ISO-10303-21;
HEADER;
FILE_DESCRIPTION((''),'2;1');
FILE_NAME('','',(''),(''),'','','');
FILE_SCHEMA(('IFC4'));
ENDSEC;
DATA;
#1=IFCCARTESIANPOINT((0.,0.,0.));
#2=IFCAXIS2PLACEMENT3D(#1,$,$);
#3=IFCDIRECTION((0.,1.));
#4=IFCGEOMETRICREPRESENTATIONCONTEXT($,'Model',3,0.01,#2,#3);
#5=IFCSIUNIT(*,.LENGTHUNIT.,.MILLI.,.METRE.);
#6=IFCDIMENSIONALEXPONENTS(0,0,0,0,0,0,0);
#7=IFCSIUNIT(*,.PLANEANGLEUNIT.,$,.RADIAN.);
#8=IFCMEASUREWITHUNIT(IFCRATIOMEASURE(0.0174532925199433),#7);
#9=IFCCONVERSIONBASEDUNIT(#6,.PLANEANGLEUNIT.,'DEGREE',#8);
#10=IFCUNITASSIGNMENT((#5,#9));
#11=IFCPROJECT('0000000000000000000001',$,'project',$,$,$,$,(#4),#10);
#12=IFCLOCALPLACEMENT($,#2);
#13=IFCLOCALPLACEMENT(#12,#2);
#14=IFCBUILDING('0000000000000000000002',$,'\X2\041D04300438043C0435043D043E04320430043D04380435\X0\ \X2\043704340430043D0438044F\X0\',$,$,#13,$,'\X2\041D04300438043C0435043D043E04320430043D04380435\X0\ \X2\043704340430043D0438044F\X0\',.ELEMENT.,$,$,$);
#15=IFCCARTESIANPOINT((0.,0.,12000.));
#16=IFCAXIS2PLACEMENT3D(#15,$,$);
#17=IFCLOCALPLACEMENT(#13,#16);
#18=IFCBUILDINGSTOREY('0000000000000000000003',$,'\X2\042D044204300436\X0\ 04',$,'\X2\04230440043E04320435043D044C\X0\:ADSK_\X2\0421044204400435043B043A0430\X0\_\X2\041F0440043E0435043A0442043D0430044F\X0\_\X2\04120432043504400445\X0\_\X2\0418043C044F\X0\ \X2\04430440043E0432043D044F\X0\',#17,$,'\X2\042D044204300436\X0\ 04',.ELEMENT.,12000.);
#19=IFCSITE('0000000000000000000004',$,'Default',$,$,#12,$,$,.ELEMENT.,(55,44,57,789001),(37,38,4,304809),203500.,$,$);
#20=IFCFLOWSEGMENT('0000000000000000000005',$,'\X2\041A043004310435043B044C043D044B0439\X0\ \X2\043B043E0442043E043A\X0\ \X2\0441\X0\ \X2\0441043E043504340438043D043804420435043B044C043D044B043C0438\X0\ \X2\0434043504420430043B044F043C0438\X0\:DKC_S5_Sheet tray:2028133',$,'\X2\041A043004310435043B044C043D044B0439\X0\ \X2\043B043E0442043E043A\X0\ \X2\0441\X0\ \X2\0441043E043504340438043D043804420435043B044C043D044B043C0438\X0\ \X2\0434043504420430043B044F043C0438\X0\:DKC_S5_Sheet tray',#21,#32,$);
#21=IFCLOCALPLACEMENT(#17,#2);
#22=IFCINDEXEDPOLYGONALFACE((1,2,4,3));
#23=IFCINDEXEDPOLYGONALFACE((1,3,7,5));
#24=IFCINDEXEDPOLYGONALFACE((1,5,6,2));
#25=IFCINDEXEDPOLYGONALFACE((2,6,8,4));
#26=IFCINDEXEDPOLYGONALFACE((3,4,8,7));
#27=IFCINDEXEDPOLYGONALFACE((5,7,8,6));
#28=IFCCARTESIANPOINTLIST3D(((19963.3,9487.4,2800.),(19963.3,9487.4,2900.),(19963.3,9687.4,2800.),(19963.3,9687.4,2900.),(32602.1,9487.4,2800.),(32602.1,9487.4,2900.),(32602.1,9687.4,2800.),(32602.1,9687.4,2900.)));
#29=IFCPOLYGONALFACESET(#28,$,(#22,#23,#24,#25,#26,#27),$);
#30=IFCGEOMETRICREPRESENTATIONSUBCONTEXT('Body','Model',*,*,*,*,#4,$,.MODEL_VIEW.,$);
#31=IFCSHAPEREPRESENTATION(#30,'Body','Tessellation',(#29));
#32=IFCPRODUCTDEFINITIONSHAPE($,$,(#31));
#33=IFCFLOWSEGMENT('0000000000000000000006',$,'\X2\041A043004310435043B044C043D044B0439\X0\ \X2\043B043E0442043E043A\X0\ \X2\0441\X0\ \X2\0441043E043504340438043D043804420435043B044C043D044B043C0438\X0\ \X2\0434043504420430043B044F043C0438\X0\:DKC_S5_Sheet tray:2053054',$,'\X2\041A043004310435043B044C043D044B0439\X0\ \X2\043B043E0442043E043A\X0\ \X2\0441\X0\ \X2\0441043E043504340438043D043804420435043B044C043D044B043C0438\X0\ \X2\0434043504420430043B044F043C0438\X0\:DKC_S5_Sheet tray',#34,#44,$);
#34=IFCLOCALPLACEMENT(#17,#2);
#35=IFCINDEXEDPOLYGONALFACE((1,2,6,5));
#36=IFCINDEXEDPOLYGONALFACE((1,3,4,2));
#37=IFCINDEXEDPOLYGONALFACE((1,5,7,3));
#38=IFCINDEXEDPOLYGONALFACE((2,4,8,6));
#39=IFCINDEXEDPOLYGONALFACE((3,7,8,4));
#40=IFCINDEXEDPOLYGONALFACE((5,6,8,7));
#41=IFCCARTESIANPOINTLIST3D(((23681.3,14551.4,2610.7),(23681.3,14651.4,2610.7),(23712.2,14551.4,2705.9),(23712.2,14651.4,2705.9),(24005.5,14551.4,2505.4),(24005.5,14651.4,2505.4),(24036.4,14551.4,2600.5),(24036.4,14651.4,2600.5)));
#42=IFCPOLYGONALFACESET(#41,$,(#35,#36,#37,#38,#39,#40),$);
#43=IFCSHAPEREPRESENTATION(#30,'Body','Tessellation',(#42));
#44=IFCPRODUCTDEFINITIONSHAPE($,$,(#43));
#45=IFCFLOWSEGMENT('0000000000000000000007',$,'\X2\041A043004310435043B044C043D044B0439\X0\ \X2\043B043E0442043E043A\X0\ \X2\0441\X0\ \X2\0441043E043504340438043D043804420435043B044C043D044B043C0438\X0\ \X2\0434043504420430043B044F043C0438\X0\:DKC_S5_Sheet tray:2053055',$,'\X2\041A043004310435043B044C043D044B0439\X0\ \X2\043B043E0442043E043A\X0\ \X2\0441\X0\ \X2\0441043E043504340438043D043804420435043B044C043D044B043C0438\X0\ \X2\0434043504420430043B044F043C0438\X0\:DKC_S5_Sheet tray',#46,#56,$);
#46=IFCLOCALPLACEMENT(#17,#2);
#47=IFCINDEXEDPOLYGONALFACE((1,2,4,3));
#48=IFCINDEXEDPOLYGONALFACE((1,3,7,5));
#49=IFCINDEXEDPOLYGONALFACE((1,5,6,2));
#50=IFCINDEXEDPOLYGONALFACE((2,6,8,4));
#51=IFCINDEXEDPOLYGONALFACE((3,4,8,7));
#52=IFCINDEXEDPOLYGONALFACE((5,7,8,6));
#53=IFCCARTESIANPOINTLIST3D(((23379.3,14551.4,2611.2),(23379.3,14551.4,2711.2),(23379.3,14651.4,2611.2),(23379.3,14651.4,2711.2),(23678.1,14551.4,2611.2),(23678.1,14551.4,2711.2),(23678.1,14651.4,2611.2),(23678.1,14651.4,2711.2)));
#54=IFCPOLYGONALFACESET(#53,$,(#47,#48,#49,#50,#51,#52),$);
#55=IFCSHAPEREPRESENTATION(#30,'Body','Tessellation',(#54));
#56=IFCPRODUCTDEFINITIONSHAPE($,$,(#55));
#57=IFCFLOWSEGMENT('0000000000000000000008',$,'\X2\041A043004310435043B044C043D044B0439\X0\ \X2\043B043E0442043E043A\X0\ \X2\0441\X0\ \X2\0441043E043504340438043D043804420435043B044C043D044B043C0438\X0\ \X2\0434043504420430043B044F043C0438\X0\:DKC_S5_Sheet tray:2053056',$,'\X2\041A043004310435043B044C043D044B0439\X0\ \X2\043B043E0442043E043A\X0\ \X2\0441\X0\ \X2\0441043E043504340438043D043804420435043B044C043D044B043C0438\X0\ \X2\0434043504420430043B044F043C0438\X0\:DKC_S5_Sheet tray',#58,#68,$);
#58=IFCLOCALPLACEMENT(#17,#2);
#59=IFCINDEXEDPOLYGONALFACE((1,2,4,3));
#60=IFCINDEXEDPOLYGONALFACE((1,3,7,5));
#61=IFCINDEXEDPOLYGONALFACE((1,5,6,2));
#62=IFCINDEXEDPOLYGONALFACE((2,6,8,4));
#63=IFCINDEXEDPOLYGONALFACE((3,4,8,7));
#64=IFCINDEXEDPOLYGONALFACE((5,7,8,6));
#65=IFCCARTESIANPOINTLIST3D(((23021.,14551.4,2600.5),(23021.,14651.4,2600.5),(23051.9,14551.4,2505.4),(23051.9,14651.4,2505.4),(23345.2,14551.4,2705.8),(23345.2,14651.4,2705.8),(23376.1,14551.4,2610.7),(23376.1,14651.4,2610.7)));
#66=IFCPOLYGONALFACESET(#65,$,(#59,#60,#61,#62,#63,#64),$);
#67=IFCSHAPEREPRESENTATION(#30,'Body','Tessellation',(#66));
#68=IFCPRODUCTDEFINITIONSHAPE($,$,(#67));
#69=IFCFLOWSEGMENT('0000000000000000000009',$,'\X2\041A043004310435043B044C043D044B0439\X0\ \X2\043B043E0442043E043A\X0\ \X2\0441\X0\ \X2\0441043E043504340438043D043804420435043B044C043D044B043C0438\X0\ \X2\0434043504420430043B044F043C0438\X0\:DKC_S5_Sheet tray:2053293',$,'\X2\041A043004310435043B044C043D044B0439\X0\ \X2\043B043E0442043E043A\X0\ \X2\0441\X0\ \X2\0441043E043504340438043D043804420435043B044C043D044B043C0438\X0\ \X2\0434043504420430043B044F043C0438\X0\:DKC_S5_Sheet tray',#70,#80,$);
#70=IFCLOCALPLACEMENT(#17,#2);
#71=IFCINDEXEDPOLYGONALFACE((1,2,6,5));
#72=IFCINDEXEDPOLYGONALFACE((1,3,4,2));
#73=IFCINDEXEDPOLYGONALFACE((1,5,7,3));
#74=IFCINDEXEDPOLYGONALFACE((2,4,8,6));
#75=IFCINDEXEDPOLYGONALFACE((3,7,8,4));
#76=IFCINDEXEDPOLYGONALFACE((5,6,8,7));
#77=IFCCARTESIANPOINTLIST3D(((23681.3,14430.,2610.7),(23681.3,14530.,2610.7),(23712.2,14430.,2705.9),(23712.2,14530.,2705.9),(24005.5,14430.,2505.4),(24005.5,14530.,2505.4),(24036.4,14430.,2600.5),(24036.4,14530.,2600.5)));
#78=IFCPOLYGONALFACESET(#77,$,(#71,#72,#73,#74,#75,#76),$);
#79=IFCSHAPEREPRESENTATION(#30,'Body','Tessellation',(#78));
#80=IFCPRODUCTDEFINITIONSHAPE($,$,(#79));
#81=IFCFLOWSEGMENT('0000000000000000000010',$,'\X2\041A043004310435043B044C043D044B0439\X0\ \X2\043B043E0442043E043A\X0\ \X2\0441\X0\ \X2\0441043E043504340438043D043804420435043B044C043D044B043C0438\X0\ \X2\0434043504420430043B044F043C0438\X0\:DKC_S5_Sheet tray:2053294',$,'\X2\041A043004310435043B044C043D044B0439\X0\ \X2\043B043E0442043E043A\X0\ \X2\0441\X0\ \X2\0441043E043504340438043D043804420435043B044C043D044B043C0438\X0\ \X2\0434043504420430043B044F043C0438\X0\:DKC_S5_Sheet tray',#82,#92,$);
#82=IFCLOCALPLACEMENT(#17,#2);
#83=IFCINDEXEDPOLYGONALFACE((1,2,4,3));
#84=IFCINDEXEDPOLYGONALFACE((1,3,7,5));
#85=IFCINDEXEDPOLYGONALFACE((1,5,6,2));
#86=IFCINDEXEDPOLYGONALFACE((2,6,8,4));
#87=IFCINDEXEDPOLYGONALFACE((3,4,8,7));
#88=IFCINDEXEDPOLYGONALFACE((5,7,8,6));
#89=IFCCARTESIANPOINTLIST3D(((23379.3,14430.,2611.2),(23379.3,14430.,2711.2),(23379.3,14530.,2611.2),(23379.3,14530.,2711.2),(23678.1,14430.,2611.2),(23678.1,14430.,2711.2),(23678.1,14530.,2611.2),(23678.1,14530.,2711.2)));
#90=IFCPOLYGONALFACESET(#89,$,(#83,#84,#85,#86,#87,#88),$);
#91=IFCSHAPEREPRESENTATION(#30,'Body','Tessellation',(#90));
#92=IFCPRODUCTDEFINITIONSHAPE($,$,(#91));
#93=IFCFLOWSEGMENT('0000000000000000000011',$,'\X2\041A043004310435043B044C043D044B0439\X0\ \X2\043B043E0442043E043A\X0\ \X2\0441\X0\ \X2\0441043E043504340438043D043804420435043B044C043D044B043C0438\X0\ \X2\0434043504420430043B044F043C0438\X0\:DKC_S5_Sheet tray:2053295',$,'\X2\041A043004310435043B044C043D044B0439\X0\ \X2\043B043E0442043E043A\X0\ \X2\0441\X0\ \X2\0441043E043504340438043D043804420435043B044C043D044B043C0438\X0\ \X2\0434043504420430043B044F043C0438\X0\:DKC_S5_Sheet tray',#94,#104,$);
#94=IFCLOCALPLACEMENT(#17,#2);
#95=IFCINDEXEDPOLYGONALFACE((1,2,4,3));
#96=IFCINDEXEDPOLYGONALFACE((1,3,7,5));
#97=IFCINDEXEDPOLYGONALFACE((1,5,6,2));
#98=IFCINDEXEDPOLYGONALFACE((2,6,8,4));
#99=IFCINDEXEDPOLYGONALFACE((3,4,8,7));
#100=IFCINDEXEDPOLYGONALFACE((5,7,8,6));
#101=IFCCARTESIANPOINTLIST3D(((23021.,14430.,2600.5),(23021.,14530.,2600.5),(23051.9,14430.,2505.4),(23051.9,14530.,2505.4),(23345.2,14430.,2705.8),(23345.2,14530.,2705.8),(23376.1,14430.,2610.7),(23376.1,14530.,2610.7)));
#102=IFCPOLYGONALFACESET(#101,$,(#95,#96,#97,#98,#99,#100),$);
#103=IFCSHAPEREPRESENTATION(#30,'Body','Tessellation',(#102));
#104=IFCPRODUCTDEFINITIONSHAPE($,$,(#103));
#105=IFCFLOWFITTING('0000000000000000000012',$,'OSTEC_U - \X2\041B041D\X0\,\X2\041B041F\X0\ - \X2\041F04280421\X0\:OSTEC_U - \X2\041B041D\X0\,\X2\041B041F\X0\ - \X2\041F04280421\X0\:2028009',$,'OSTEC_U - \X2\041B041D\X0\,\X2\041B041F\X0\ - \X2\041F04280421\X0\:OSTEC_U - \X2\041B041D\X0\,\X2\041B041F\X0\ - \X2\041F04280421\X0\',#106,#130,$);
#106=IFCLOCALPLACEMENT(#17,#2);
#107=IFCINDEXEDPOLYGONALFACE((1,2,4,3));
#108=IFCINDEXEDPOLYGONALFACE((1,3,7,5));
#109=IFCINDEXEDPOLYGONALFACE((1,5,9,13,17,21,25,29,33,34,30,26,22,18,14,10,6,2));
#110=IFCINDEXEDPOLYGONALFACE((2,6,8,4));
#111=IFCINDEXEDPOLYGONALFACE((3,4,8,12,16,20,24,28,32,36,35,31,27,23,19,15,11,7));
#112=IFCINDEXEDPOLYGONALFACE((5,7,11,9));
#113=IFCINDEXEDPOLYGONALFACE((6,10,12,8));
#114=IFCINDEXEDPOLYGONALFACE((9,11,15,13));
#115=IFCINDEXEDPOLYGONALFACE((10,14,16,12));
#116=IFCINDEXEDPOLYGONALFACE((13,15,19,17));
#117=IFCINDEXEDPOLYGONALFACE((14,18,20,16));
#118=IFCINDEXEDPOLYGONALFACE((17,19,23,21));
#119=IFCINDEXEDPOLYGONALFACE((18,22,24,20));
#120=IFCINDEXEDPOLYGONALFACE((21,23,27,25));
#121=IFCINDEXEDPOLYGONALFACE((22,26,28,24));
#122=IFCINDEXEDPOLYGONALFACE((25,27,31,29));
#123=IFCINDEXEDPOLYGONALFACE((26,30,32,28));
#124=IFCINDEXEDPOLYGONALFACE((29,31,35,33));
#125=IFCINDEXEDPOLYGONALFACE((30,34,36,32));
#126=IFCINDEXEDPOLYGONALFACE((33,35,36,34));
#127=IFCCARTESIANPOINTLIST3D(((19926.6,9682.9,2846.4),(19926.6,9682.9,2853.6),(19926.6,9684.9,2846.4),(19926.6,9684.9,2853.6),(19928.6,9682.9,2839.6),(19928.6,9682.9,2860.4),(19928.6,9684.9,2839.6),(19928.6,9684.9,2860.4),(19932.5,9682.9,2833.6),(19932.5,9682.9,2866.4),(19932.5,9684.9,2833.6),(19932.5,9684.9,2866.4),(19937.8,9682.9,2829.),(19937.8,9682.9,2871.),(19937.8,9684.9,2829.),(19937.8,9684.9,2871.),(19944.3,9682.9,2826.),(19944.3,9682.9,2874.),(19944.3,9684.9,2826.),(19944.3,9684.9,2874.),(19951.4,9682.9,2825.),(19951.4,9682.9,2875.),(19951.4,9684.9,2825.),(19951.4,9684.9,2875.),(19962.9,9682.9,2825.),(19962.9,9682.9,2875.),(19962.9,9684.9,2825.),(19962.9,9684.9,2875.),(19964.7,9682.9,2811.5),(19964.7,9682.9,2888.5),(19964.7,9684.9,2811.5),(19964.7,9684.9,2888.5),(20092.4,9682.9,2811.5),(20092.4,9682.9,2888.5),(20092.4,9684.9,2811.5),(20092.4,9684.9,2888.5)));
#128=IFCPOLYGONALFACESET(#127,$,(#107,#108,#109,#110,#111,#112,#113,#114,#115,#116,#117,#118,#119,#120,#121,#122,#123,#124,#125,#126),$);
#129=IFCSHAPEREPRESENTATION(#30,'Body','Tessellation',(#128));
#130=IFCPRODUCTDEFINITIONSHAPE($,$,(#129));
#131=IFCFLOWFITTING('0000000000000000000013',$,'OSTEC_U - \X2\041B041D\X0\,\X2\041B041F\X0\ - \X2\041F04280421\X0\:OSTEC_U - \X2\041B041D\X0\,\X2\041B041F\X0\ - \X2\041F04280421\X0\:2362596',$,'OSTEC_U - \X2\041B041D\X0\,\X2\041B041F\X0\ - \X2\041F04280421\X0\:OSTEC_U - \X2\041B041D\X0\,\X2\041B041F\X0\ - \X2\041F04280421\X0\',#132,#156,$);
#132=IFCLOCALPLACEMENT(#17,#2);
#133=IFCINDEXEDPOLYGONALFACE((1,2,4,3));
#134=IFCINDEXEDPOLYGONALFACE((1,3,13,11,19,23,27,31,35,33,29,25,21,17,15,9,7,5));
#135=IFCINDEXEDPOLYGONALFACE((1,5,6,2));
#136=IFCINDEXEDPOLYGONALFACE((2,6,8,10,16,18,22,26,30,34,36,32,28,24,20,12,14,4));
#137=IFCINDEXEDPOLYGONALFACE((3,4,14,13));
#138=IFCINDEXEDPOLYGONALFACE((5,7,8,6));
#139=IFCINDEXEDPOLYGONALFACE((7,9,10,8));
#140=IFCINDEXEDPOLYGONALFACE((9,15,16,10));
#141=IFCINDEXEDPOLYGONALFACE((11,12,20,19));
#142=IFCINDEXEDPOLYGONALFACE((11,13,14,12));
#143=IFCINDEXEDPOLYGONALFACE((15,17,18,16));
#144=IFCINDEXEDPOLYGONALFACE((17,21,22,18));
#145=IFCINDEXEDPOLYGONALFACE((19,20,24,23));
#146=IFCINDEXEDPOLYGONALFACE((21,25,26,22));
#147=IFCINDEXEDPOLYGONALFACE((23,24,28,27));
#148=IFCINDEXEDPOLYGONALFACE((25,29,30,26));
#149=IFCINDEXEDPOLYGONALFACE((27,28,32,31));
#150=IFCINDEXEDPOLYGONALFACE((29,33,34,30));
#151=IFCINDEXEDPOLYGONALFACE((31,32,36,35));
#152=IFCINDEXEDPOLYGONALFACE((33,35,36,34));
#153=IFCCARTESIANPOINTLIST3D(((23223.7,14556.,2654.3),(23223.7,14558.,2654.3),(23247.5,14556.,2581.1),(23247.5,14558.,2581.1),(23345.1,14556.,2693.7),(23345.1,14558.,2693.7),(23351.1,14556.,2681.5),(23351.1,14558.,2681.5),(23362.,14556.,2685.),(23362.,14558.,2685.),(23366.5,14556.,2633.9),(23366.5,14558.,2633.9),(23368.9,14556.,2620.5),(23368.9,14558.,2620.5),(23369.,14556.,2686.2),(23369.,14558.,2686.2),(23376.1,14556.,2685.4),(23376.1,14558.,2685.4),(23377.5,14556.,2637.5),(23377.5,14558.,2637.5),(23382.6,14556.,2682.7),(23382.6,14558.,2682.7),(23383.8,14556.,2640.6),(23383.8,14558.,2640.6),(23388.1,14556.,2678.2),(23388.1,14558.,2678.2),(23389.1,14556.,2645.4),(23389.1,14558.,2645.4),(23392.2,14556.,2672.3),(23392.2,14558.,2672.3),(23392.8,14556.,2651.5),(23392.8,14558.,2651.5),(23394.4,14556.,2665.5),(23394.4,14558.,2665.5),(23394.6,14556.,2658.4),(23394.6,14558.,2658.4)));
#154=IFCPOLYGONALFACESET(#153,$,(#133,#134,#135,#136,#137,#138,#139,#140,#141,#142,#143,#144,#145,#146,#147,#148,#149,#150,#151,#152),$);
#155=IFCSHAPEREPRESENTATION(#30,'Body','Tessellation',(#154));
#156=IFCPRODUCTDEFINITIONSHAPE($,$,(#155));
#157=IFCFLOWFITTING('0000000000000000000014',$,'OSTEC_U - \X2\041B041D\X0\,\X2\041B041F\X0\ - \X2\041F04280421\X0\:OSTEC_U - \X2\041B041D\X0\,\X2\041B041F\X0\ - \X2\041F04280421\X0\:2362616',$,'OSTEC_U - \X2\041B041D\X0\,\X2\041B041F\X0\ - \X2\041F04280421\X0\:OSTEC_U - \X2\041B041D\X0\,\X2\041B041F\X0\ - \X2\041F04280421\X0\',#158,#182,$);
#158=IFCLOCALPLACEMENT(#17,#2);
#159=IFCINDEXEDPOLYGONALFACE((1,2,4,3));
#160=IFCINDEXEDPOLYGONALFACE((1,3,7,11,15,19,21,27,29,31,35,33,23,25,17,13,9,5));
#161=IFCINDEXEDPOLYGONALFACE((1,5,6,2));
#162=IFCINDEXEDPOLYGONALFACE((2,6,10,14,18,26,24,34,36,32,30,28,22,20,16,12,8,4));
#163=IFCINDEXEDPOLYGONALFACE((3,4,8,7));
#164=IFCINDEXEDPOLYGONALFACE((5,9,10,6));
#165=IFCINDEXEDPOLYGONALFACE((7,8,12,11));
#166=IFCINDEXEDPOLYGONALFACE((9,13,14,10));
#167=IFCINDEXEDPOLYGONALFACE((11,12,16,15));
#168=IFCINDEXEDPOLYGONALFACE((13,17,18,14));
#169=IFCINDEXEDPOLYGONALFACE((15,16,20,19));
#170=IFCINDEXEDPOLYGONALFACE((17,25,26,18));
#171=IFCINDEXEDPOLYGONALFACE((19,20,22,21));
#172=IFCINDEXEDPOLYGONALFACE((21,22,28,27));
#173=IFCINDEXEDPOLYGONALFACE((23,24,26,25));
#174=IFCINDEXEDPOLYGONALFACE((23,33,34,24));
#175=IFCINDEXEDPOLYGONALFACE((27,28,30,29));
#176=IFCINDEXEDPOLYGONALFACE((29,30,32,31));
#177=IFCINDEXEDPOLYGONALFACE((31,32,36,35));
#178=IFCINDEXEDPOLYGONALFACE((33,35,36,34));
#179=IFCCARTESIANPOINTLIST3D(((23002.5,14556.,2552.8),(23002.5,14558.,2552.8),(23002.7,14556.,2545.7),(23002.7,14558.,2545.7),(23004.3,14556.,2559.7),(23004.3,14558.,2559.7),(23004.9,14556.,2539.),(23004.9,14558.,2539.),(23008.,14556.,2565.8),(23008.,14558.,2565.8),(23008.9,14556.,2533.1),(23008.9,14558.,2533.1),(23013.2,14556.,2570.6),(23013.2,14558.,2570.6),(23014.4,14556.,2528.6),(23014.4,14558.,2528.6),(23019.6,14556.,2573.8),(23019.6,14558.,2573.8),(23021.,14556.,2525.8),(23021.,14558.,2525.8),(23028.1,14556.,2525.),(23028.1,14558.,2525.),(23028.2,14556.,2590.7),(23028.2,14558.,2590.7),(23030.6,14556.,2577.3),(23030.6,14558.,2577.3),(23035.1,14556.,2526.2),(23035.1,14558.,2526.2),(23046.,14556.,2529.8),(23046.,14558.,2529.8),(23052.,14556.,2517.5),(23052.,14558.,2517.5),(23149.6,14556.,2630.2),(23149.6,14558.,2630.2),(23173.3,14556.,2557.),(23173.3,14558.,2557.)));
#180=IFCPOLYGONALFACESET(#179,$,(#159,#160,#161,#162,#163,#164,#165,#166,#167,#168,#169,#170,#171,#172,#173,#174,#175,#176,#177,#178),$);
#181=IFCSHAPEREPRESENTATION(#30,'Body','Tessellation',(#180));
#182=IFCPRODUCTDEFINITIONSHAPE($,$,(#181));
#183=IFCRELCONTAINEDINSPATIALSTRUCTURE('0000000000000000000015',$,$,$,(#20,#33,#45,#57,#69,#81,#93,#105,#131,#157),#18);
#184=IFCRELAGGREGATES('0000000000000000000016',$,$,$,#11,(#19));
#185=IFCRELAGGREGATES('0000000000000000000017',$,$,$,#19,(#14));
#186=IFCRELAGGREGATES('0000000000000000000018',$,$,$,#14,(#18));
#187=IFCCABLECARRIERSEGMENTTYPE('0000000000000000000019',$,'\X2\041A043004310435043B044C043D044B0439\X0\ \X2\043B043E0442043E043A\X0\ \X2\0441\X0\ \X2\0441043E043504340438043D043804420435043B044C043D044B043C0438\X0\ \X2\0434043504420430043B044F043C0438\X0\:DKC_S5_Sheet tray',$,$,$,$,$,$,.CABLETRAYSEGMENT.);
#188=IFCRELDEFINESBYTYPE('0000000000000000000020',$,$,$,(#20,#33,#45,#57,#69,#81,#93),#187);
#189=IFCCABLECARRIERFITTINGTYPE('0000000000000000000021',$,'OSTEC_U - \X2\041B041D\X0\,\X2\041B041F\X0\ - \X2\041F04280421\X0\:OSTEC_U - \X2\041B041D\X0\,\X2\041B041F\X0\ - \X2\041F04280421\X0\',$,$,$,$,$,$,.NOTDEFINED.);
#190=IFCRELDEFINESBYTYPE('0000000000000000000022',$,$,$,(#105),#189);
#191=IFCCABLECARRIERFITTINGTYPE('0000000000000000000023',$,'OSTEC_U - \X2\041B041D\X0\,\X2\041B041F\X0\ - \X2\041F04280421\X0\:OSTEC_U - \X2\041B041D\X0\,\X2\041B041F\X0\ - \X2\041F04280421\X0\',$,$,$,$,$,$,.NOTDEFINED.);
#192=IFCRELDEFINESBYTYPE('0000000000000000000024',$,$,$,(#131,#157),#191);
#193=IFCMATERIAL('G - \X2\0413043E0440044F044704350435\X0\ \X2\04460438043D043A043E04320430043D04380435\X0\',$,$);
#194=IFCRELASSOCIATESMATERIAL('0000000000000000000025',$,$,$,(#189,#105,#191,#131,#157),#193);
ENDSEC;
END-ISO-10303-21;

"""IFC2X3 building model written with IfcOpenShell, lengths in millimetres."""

from ifc_helpers import new_model, entity, si_unit, converted_unit, direction, frame, frame_2d, origin, origin_2d_with_axis, place, context, subcontext, project, spatial, polyline, circle_curve, parameter, trimmed, segment, composite_curve, rectangle, outline, extrude, source, transform, mapped, material, type_object, type_shapes, element, save


model = new_model("IFC2X3")

# Units and contexts
model_context = context("Model", 3, precision=0.01, world=origin(), true_north=direction((0.0, 1.0)))
body_context = subcontext(model_context, "Body", "Model", "MODEL_VIEW")
ifc_project = project(units=[si_unit("LENGTHUNIT", "METRE", prefix="MILLI"), converted_unit("PLANEANGLEUNIT", "DEGREE", entity("IfcRatioMeasure", 0.0174532925199433), si_unit("PLANEANGLEUNIT", "RADIAN"), dimensions=[0, 0, 0, 0, 0, 0, 0])], contexts=[model_context])

# Site, building, storey
site_placement = place(None, origin())
site = spatial("IfcSite", under=ifc_project, at=site_placement, Name="Default", CompositionType="ELEMENT", RefLatitude=(55, 44, 57, 789001), RefLongitude=(37, 38, 4, 304809), RefElevation=203500.0)
building_placement = place(site_placement, origin())
building = spatial("IfcBuilding", under=site, at=building_placement, Name="Наименование здания", LongName="Наименование здания", CompositionType="ELEMENT")
storey_placement = place(building_placement, frame((0.0, 0.0, 12000.0)))
storey = spatial("IfcBuildingStorey", under=building, at=storey_placement, Name="Этаж 04", ObjectType="Уровень:ADSK_Стрелка_Проектная_Вверх_Имя уровня", LongName="Этаж 04", CompositionType="ELEMENT", Elevation=12000.0)

# Flow segments
cable_carrier_segment_type = type_object("IfcCableCarrierSegmentType", Name="Кабельный лоток с соединительными деталями:DKC_S5_Sheet tray", PredefinedType="CABLETRAYSEGMENT")
flow_segment_1_placement = place(storey_placement, frame((19963.3, 9487.5, 2800.0)))
element("IfcFlowSegment", 1, at=flow_segment_1_placement, inside=storey, type_object=cable_carrier_segment_type, Name="Кабельный лоток с соединительными деталями:DKC_S5_Sheet tray:2028133", ObjectType="Кабельный лоток с соединительными деталями:DKC_S5_Sheet tray", context=body_context, shape_type="SweptSolid", body=[
    extrude(rectangle(XDim=12638.7, YDim=200.0, at=origin_2d_with_axis()), frame((6319.4, 100.0, 0.0)), (0.0, 0.0, 1.0), 100.0),
])
flow_segment_2_placement = place(storey_placement, frame((23681.3, 14551.4, 2505.4)))
element("IfcFlowSegment", 2, at=flow_segment_2_placement, inside=storey, type_object=cable_carrier_segment_type, Name="Кабельный лоток с соединительными деталями:DKC_S5_Sheet tray:2053054", ObjectType="Кабельный лоток с соединительными деталями:DKC_S5_Sheet tray", context=body_context, shape_type="SweptSolid", body=[
    extrude(rectangle(XDim=100.0, YDim=100.0, at=origin_2d_with_axis()), frame((15.4, 50.0, 152.9), z_axis=(0.951057, 0.0, -0.309017), x_axis=(0.309017, 0.0, 0.951057)), (0.0, 0.0, 1.0), 340.9),
])
flow_segment_3_placement = place(storey_placement, frame((23379.3, 14551.4, 2611.2)))
element("IfcFlowSegment", 3, at=flow_segment_3_placement, inside=storey, type_object=cable_carrier_segment_type, Name="Кабельный лоток с соединительными деталями:DKC_S5_Sheet tray:2053055", ObjectType="Кабельный лоток с соединительными деталями:DKC_S5_Sheet tray", context=body_context, shape_type="SweptSolid", body=[
    extrude(rectangle(XDim=298.8, YDim=100.0, at=origin_2d_with_axis()), frame((149.4, 50.0, 0.0), z_axis=(0.0, 0.0, 1.0), x_axis=(-1.0, 0.0, 0.0)), (0.0, 0.0, 1.0), 100.0),
])
flow_segment_4_placement = place(storey_placement, frame((23021.0, 14551.4, 2505.4)))
element("IfcFlowSegment", 4, at=flow_segment_4_placement, inside=storey, type_object=cable_carrier_segment_type, Name="Кабельный лоток с соединительными деталями:DKC_S5_Sheet tray:2053056", ObjectType="Кабельный лоток с соединительными деталями:DKC_S5_Sheet tray", context=body_context, shape_type="SweptSolid", body=[
    extrude(rectangle(XDim=100.0, YDim=100.0, at=frame_2d((0.0, 0.0), x_axis=(0.0, 1.0))), frame((15.4, 50.0, 47.5), z_axis=(0.951057, 0.0, 0.309017), x_axis=(0.0, 1.0, 0.0)), (0.0, 0.0, 1.0), 340.9),
])
flow_segment_5_placement = place(storey_placement, frame((23681.3, 14430.0, 2505.4)))
element("IfcFlowSegment", 5, at=flow_segment_5_placement, inside=storey, type_object=cable_carrier_segment_type, Name="Кабельный лоток с соединительными деталями:DKC_S5_Sheet tray:2053293", ObjectType="Кабельный лоток с соединительными деталями:DKC_S5_Sheet tray", context=body_context, shape_type="SweptSolid", body=[
    extrude(rectangle(XDim=100.0, YDim=100.0, at=origin_2d_with_axis()), frame((15.4, 50.0, 152.9), z_axis=(0.951057, 0.0, -0.309017), x_axis=(0.309017, 0.0, 0.951057)), (0.0, 0.0, 1.0), 340.9),
])
flow_segment_6_placement = place(storey_placement, frame((23379.3, 14430.0, 2611.2)))
element("IfcFlowSegment", 6, at=flow_segment_6_placement, inside=storey, type_object=cable_carrier_segment_type, Name="Кабельный лоток с соединительными деталями:DKC_S5_Sheet tray:2053294", ObjectType="Кабельный лоток с соединительными деталями:DKC_S5_Sheet tray", context=body_context, shape_type="SweptSolid", body=[
    extrude(rectangle(XDim=298.8, YDim=100.0, at=origin_2d_with_axis()), frame((149.4, 50.0, 0.0), z_axis=(0.0, 0.0, 1.0), x_axis=(-1.0, 0.0, 0.0)), (0.0, 0.0, 1.0), 100.0),
])
flow_segment_7_placement = place(storey_placement, frame((23021.0, 14430.0, 2505.4)))
element("IfcFlowSegment", 7, at=flow_segment_7_placement, inside=storey, type_object=cable_carrier_segment_type, Name="Кабельный лоток с соединительными деталями:DKC_S5_Sheet tray:2053295", ObjectType="Кабельный лоток с соединительными деталями:DKC_S5_Sheet tray", context=body_context, shape_type="SweptSolid", body=[
    extrude(rectangle(XDim=100.0, YDim=100.0, at=frame_2d((0.0, 0.0), x_axis=(0.0, 1.0))), frame((15.4, 50.0, 47.5), z_axis=(0.951057, 0.0, 0.309017), x_axis=(0.0, 1.0, 0.0)), (0.0, 0.0, 1.0), 340.9),
])

# Flow fittings
ifc_material = material(Name="G - Горячее цинкование")
cable_carrier_fitting_type_1 = type_object("IfcCableCarrierFittingType", Name="OSTEC_U - ЛН,ЛП - ПШС:OSTEC_U - ЛН,ЛП - ПШС", PredefinedType="NOTDEFINED", material=ifc_material)
shared_shape_1 = source(origin(), body_context, "Body", "SweptSolid", [
    extrude(outline(composite_curve([segment(trimmed(circle_curve(frame_2d((-41.5, 0.0), x_axis=(1.0, 0.0)), 25.0), [parameter(90.0)], [parameter(270.0)], True, "PARAMETER"), True, "CONTINUOUS"), segment(polyline([(-41.5, -25.0), (-30.0, -25.0)]), True, "CONTINUOUS"), segment(polyline([(-30.0, -25.0), (-28.1, -38.5)]), True, "CONTINUOUS"), segment(polyline([(-28.1, -38.5), (99.5, -38.5)]), True, "CONTINUOUS"), segment(polyline([(99.5, -38.5), (99.5, 38.5)]), True, "CONTINUOUS"), segment(polyline([(99.5, 38.5), (-28.1, 38.5)]), True, "CONTINUOUS"), segment(polyline([(-28.1, 38.5), (-30.0, 25.0)]), True, "CONTINUOUS"), segment(polyline([(-30.0, 25.0), (-41.5, 25.0)]), True, "CONTINUOUS")], self_intersect=False)), frame((41.5, 0.0, 0.0), z_axis=(0.0, 0.0, -1.0), x_axis=(1.0, 0.0, 0.0)), (0.0, 0.0, -1.0), 2.0),
])
type_shapes(cable_carrier_fitting_type_1, [shared_shape_1])
flow_fitting_1_placement = place(storey_placement, frame((19951.4, 9682.9, 2850.0), z_axis=(0.0, 1.0, 0.0), x_axis=(1.0, 0.0, 0.0)))
element("IfcFlowFitting", 8, at=flow_fitting_1_placement, inside=storey, type_object=cable_carrier_fitting_type_1, material=ifc_material, Name="OSTEC_U - ЛН,ЛП - ПШС:OSTEC_U - ЛН,ЛП - ПШС:2028009", ObjectType="OSTEC_U - ЛН,ЛП - ПШС:OSTEC_U - ЛН,ЛП - ПШС", context=body_context, shape_type="MappedRepresentation", body=[
    mapped(shared_shape_1, transform((0.0, 0.0, 0.0), scale=1.0)),
])
cable_carrier_fitting_type_2 = type_object("IfcCableCarrierFittingType", Name="OSTEC_U - ЛН,ЛП - ПШС:OSTEC_U - ЛН,ЛП - ПШС", PredefinedType="NOTDEFINED", material=ifc_material)
type_shapes(cable_carrier_fitting_type_2, [shared_shape_1])
for number, where, z_axis, x_axis, name in (
    (9, (23369.7, 14558.0, 2661.2), (0.0, -1.0, 0.0), (-0.951057, 0.0, -0.309017), "OSTEC_U - ЛН,ЛП - ПШС:OSTEC_U - ЛН,ЛП - ПШС:2362596"),
    (10, (23027.3, 14558.0, 2550.0), (0.0, -1.0, 0.0), (0.951057, 0.0, 0.309017), "OSTEC_U - ЛН,ЛП - ПШС:OSTEC_U - ЛН,ЛП - ПШС:2362616"),
):
    element("IfcFlowFitting", number, at=place(storey_placement, frame(where, z_axis=z_axis, x_axis=x_axis)), inside=storey, type_object=cable_carrier_fitting_type_2, material=ifc_material, Name=name, ObjectType="OSTEC_U - ЛН,ЛП - ПШС:OSTEC_U - ЛН,ЛП - ПШС", context=body_context, shape_type="MappedRepresentation", body=[
        mapped(shared_shape_1, transform((0.0, 0.0, 0.0), scale=1.0)),
    ])

save(model, "model.ifc")
